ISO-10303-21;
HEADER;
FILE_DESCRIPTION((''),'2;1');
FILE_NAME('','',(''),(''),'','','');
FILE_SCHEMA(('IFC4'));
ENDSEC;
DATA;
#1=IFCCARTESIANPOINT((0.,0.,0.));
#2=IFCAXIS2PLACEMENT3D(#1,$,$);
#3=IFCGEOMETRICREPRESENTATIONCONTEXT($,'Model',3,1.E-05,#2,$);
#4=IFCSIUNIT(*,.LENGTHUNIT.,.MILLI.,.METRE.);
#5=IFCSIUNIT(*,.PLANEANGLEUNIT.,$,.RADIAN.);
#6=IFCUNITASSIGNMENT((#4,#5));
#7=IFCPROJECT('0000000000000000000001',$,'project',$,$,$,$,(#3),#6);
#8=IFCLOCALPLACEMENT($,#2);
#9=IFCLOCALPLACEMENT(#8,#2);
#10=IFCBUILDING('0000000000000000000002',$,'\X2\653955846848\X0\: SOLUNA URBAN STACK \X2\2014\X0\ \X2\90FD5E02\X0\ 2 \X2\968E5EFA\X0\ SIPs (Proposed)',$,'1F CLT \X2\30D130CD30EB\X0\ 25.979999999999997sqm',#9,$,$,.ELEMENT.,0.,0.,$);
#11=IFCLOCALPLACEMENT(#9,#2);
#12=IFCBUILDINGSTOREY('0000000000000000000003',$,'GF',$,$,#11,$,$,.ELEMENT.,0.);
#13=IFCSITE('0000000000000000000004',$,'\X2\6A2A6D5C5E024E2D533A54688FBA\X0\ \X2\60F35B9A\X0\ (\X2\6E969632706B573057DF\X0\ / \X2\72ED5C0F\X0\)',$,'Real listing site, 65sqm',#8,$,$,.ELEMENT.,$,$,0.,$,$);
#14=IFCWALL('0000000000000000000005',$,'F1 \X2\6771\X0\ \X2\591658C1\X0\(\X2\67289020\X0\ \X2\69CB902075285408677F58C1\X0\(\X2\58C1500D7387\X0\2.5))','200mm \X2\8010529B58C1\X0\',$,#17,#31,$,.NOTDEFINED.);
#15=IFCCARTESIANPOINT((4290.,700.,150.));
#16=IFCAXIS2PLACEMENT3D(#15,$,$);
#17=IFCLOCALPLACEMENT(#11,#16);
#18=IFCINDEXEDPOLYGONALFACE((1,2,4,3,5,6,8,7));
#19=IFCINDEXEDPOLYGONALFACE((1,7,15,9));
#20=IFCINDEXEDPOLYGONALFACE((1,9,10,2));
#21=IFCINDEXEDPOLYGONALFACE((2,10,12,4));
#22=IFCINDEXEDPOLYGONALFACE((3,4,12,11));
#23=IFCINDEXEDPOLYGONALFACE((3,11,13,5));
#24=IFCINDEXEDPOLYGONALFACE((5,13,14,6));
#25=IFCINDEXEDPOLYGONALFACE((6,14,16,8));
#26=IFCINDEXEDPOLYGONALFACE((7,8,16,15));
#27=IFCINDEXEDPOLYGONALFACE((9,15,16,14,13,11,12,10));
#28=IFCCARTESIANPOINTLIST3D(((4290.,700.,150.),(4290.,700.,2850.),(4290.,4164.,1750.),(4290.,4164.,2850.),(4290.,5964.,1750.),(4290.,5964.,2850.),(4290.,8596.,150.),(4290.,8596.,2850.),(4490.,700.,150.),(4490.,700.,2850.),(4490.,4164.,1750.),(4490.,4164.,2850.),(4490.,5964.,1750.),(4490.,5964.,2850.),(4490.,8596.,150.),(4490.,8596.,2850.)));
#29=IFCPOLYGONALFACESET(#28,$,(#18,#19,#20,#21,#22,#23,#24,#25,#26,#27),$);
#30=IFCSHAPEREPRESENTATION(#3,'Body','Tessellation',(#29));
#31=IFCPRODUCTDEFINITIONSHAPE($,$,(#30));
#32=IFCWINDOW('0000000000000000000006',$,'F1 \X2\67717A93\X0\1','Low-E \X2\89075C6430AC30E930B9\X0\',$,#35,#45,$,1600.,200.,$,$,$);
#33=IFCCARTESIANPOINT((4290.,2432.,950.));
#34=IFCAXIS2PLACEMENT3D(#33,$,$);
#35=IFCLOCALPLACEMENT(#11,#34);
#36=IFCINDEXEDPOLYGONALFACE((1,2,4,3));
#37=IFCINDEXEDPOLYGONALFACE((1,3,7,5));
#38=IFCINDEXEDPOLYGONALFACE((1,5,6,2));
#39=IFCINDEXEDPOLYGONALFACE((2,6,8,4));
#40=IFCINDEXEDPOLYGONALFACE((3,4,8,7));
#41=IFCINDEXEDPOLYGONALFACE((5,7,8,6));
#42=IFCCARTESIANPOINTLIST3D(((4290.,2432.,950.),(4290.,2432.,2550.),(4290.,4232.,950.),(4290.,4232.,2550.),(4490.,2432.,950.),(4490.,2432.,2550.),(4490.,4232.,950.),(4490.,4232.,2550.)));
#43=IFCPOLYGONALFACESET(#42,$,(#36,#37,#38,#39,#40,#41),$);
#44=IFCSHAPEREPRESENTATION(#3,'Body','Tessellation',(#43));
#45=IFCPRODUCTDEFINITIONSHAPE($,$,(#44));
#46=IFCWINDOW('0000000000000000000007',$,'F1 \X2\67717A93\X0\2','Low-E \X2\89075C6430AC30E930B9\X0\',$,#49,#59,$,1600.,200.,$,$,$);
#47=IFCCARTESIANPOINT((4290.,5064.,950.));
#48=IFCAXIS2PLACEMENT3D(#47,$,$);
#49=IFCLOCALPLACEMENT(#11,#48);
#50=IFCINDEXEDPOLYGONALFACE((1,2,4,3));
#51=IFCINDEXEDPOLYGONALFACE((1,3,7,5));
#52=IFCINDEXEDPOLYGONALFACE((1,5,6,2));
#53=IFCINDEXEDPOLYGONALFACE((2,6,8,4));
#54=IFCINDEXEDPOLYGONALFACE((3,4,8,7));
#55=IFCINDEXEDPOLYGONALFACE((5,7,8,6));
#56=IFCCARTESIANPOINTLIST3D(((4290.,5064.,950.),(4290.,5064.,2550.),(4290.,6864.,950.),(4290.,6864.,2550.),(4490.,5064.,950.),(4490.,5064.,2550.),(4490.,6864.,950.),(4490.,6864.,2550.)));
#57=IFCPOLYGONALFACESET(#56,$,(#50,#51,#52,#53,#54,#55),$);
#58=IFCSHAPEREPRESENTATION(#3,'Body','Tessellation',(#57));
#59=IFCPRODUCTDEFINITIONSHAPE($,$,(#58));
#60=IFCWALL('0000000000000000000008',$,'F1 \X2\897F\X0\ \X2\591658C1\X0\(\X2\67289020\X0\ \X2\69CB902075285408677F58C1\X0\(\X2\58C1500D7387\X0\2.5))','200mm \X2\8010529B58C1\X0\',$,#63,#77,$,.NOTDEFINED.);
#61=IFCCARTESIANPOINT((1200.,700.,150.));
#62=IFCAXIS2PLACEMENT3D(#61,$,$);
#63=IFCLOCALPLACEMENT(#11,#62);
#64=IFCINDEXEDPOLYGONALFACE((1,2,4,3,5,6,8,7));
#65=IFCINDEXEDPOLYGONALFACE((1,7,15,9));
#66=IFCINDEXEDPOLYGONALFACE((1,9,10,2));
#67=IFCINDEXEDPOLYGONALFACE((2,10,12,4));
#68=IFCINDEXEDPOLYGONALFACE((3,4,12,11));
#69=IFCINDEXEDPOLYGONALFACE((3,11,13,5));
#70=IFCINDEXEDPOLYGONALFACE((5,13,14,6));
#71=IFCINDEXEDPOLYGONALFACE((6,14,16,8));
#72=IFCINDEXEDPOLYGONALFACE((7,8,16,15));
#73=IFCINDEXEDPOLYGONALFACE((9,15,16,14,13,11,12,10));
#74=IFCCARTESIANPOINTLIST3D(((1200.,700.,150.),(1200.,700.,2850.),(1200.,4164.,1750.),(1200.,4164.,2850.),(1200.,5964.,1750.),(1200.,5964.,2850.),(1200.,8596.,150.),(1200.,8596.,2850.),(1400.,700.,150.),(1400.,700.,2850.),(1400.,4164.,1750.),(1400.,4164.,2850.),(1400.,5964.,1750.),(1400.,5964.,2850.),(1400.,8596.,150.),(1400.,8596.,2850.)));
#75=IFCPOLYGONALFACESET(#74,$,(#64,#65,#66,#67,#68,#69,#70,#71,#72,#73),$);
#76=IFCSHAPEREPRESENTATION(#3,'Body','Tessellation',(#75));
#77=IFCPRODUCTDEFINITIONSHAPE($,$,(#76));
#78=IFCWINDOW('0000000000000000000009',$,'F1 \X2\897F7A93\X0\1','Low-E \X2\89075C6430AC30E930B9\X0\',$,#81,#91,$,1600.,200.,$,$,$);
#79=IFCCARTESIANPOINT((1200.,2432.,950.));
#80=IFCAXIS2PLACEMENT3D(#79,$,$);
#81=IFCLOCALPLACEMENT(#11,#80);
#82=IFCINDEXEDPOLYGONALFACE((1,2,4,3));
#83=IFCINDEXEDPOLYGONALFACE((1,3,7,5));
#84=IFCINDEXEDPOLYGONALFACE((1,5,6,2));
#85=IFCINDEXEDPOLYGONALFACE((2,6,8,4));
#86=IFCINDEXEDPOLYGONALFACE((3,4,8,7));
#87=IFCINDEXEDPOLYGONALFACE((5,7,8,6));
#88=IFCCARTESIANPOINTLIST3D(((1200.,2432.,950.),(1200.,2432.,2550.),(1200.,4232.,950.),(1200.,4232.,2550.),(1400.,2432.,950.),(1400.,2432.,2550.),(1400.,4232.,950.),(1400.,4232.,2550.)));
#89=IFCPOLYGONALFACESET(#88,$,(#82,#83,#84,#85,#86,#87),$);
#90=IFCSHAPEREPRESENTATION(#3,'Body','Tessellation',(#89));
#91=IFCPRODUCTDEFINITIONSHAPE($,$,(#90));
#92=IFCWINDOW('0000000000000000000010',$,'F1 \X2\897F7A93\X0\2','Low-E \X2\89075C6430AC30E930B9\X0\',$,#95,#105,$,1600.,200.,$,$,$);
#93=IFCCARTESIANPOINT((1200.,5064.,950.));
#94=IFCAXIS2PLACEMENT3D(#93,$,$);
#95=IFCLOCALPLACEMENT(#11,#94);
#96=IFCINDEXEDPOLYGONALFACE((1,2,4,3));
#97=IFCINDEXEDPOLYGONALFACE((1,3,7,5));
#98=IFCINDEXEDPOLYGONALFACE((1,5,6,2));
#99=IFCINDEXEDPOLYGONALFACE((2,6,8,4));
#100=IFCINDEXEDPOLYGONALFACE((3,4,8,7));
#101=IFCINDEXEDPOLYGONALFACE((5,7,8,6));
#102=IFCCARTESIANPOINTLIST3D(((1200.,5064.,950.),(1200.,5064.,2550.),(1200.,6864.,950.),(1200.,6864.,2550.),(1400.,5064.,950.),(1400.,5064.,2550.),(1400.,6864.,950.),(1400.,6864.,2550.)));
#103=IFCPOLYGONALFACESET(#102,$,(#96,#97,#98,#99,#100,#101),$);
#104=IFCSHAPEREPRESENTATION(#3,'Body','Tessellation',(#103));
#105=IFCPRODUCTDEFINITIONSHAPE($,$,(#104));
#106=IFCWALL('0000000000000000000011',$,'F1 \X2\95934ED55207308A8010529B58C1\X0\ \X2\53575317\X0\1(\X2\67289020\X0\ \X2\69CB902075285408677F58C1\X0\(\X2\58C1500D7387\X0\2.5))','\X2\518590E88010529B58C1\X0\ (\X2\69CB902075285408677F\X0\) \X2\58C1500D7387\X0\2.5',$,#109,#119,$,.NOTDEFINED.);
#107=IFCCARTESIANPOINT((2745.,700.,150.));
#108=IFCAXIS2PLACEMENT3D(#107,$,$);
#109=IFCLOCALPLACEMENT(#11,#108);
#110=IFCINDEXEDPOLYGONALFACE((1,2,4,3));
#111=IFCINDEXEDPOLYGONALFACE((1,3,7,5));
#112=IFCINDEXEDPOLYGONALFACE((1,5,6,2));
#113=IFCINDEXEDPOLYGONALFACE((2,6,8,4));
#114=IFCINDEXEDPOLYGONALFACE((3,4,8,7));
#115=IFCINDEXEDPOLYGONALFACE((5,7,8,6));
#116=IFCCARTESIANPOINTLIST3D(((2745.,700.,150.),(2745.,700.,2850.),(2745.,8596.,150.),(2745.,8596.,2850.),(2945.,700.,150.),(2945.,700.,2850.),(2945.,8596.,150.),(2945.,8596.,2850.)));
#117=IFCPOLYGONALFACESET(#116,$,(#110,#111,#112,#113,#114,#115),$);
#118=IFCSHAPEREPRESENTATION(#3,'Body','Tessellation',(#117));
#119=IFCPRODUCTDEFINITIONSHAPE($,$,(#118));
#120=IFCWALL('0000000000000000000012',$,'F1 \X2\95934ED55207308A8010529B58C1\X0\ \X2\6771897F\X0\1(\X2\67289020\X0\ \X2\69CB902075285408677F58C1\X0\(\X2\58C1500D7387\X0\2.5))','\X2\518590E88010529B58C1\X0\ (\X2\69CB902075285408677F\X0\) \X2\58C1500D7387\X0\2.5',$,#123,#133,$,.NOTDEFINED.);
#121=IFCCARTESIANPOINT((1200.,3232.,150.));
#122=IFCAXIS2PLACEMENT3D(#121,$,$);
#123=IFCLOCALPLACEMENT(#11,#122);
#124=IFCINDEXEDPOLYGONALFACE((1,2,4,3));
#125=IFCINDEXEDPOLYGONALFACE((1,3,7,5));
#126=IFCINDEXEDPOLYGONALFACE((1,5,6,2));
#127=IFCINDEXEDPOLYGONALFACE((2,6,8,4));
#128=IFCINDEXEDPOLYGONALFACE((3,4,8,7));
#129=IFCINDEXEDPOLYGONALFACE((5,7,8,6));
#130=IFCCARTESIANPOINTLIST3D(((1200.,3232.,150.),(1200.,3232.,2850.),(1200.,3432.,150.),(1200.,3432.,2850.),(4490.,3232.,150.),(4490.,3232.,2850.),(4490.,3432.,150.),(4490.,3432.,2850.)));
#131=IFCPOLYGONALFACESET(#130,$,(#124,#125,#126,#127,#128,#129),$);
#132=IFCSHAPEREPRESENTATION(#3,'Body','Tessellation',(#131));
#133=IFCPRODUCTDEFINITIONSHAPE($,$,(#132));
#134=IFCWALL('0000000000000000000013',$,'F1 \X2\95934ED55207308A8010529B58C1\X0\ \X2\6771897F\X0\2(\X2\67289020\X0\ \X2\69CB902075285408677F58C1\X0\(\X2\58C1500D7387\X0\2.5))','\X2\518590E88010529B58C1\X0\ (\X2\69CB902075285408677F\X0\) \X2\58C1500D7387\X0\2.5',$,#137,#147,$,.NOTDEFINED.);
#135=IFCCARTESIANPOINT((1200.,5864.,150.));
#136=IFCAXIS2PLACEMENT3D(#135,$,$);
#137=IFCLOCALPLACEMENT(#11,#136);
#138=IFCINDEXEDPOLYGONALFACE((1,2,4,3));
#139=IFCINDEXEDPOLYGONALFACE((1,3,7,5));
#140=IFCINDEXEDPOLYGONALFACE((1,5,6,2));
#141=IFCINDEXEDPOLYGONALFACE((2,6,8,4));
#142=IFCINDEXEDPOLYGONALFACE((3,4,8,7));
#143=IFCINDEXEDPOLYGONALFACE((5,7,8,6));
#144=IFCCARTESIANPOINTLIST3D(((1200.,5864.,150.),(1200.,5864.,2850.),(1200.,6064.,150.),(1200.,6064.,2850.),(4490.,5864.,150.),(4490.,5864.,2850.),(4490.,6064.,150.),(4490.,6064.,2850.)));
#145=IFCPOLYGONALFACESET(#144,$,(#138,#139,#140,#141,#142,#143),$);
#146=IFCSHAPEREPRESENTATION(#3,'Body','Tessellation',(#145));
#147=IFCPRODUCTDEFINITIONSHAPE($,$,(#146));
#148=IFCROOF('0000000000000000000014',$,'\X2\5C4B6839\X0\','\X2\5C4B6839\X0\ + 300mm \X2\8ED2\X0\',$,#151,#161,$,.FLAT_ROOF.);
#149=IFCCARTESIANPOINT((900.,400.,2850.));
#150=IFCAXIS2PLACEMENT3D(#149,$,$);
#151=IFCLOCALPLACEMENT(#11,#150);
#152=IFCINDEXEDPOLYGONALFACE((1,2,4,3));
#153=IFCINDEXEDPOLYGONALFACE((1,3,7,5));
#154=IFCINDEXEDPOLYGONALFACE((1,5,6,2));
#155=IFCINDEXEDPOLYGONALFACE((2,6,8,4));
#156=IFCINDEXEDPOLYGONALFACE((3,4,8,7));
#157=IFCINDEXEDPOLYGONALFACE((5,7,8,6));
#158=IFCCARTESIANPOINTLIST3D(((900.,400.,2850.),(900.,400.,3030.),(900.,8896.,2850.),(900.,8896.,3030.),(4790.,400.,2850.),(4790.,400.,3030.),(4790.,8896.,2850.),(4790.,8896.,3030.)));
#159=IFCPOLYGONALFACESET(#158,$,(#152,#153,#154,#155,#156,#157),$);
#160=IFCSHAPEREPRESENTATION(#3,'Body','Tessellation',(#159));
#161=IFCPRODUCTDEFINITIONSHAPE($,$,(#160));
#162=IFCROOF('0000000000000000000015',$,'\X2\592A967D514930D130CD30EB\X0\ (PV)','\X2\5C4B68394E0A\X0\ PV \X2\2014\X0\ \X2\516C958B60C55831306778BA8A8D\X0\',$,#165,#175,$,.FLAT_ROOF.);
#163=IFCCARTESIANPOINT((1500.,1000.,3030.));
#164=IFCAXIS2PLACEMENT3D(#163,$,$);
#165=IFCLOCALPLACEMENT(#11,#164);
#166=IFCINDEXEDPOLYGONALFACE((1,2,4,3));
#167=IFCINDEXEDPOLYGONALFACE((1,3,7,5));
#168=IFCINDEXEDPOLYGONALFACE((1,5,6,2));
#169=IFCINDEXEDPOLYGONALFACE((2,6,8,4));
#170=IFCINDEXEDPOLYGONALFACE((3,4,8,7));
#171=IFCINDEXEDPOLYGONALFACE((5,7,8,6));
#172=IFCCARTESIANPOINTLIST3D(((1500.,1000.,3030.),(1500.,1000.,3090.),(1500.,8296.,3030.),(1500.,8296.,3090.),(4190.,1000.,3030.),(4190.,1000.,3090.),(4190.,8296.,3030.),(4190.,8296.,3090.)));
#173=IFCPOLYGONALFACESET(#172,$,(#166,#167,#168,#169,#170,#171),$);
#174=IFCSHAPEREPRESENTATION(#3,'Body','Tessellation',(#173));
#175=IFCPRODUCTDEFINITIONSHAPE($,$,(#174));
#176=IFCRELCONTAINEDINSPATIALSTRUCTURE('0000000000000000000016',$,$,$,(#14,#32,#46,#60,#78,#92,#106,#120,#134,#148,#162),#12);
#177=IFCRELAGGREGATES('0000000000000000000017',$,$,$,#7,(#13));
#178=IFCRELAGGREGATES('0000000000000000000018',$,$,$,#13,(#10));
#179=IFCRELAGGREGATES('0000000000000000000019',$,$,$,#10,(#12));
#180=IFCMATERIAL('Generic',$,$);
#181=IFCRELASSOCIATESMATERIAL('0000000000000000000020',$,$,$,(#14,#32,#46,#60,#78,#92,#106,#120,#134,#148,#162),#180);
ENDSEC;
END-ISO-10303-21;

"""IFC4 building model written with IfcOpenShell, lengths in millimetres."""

from ifc_helpers import new_model, si_unit, frame, frame_2d, origin, place, context, project, spatial, rectangle, extrude, material, element, fill, save


model = new_model("IFC4")

# Units and contexts
model_context = context("Model", 3, precision=1e-05, world=origin())
ifc_project = project(units=[si_unit("LENGTHUNIT", "METRE", prefix="MILLI"), si_unit("PLANEANGLEUNIT", "RADIAN")], contexts=[model_context])

# Site, building, storey
site_placement = place(None, origin())
site = spatial("IfcSite", under=ifc_project, at=site_placement, Name="横浜市中区周辺 想定 (準防火地域 / 狭小)", ObjectType="Real listing site, 65sqm", CompositionType="ELEMENT", RefElevation=0.0)
building_placement = place(site_placement, origin())
building = spatial("IfcBuilding", under=site, at=building_placement, Name="改善案: SOLUNA URBAN STACK — 都市 2 階建 SIPs (Proposed)", ObjectType="1F CLT パネル 25.979999999999997sqm", CompositionType="ELEMENT", ElevationOfRefHeight=0.0, ElevationOfTerrain=0.0)
storey_placement = place(building_placement, origin())
storey = spatial("IfcBuildingStorey", under=building, at=storey_placement, Name="GF", CompositionType="ELEMENT", Elevation=0.0)

# Shared definitions
ifc_material_1 = material(Name="Generic")

# Walls, openings, windows
wall_1_placement = place(storey_placement, frame((4290.0, 700.0, 150.0)))
wall_1 = element("IfcWall", 1, at=wall_1_placement, inside=storey, material=ifc_material_1, Name="F1 東 外壁(木造 構造用合板壁(壁倍率2.5))", Description="200mm 耐力壁", PredefinedType="NOTDEFINED", context=model_context, shape_type="SweptSolid", body=[
    extrude(rectangle(XDim=200.0, YDim=7896.0, at=frame_2d((100.0, 3948.0))), frame((4290.0, 700.0, 150.0)), (0.0, 0.0, 1.0), 2700.0),
])
opening_1_placement = place(storey_placement, frame((4290.0, 2432.0, 950.0)))
opening_1 = element("IfcOpeningElement", 2, at=opening_1_placement, cuts=wall_1, PredefinedType="NOTDEFINED", context=model_context, shape_type="SweptSolid", body=[
    extrude(rectangle(XDim=200.0, YDim=1800.0, at=frame_2d((100.0, 900.0))), frame((4290.0, 2432.0, 950.0)), (0.0, 0.0, 1.0), 1600.0),
])
opening_2_placement = place(storey_placement, frame((4290.0, 5064.0, 950.0)))
opening_2 = element("IfcOpeningElement", 3, at=opening_2_placement, cuts=wall_1, PredefinedType="NOTDEFINED", context=model_context, shape_type="SweptSolid", body=[
    extrude(rectangle(XDim=200.0, YDim=1800.0, at=frame_2d((100.0, 900.0))), frame((4290.0, 5064.0, 950.0)), (0.0, 0.0, 1.0), 1600.0),
])
window_1_placement = place(storey_placement, frame((4290.0, 2432.0, 950.0)))
window_1 = element("IfcWindow", 4, at=window_1_placement, inside=storey, material=ifc_material_1, Name="F1 東窓1", Description="Low-E 複層ガラス", OverallHeight=1600.0, OverallWidth=200.0, context=model_context, shape_type="SweptSolid", body=[
    extrude(rectangle(XDim=200.0, YDim=1800.0, at=frame_2d((100.0, 900.0))), frame((4290.0, 2432.0, 950.0)), (0.0, 0.0, 1.0), 1600.0),
])
fill(opening_1, window_1)
window_2_placement = place(storey_placement, frame((4290.0, 5064.0, 950.0)))
window_2 = element("IfcWindow", 5, at=window_2_placement, inside=storey, material=ifc_material_1, Name="F1 東窓2", Description="Low-E 複層ガラス", OverallHeight=1600.0, OverallWidth=200.0, context=model_context, shape_type="SweptSolid", body=[
    extrude(rectangle(XDim=200.0, YDim=1800.0, at=frame_2d((100.0, 900.0))), frame((4290.0, 5064.0, 950.0)), (0.0, 0.0, 1.0), 1600.0),
])
fill(opening_2, window_2)
wall_2_placement = place(storey_placement, frame((1200.0, 700.0, 150.0)))
wall_2 = element("IfcWall", 6, at=wall_2_placement, inside=storey, material=ifc_material_1, Name="F1 西 外壁(木造 構造用合板壁(壁倍率2.5))", Description="200mm 耐力壁", PredefinedType="NOTDEFINED", context=model_context, shape_type="SweptSolid", body=[
    extrude(rectangle(XDim=200.0, YDim=7896.0, at=frame_2d((100.0, 3948.0))), frame((1200.0, 700.0, 150.0)), (0.0, 0.0, 1.0), 2700.0),
])
opening_3_placement = place(storey_placement, frame((1200.0, 2432.0, 950.0)))
opening_3 = element("IfcOpeningElement", 7, at=opening_3_placement, cuts=wall_2, PredefinedType="NOTDEFINED", context=model_context, shape_type="SweptSolid", body=[
    extrude(rectangle(XDim=200.0, YDim=1800.0, at=frame_2d((100.0, 900.0))), frame((1200.0, 2432.0, 950.0)), (0.0, 0.0, 1.0), 1600.0),
])
opening_4_placement = place(storey_placement, frame((1200.0, 5064.0, 950.0)))
opening_4 = element("IfcOpeningElement", 8, at=opening_4_placement, cuts=wall_2, PredefinedType="NOTDEFINED", context=model_context, shape_type="SweptSolid", body=[
    extrude(rectangle(XDim=200.0, YDim=1800.0, at=frame_2d((100.0, 900.0))), frame((1200.0, 5064.0, 950.0)), (0.0, 0.0, 1.0), 1600.0),
])
window_3_placement = place(storey_placement, frame((1200.0, 2432.0, 950.0)))
window_3 = element("IfcWindow", 9, at=window_3_placement, inside=storey, material=ifc_material_1, Name="F1 西窓1", Description="Low-E 複層ガラス", OverallHeight=1600.0, OverallWidth=200.0, context=model_context, shape_type="SweptSolid", body=[
    extrude(rectangle(XDim=200.0, YDim=1800.0, at=frame_2d((100.0, 900.0))), frame((1200.0, 2432.0, 950.0)), (0.0, 0.0, 1.0), 1600.0),
])
fill(opening_3, window_3)
window_4_placement = place(storey_placement, frame((1200.0, 5064.0, 950.0)))
window_4 = element("IfcWindow", 10, at=window_4_placement, inside=storey, material=ifc_material_1, Name="F1 西窓2", Description="Low-E 複層ガラス", OverallHeight=1600.0, OverallWidth=200.0, context=model_context, shape_type="SweptSolid", body=[
    extrude(rectangle(XDim=200.0, YDim=1800.0, at=frame_2d((100.0, 900.0))), frame((1200.0, 5064.0, 950.0)), (0.0, 0.0, 1.0), 1600.0),
])
fill(opening_4, window_4)

# Walls
wall_3_placement = place(storey_placement, frame((2745.0, 700.0, 150.0)))
element("IfcWall", 11, at=wall_3_placement, inside=storey, material=ifc_material_1, Name="F1 間仕切り耐力壁 南北1(木造 構造用合板壁(壁倍率2.5))", Description="内部耐力壁 (構造用合板) 壁倍率2.5", PredefinedType="NOTDEFINED", context=model_context, shape_type="SweptSolid", body=[
    extrude(rectangle(XDim=200.0, YDim=7896.0, at=frame_2d((100.0, 3948.0))), frame((2745.0, 700.0, 150.0)), (0.0, 0.0, 1.0), 2700.0),
])
wall_4_placement = place(storey_placement, frame((1200.0, 3232.0, 150.0)))
element("IfcWall", 12, at=wall_4_placement, inside=storey, material=ifc_material_1, Name="F1 間仕切り耐力壁 東西1(木造 構造用合板壁(壁倍率2.5))", Description="内部耐力壁 (構造用合板) 壁倍率2.5", PredefinedType="NOTDEFINED", context=model_context, shape_type="SweptSolid", body=[
    extrude(rectangle(XDim=3290.0, YDim=200.0, at=frame_2d((1645.0, 100.0))), frame((1200.0, 3232.0, 150.0)), (0.0, 0.0, 1.0), 2700.0),
])
wall_5_placement = place(storey_placement, frame((1200.0, 5864.0, 150.0)))
element("IfcWall", 13, at=wall_5_placement, inside=storey, material=ifc_material_1, Name="F1 間仕切り耐力壁 東西2(木造 構造用合板壁(壁倍率2.5))", Description="内部耐力壁 (構造用合板) 壁倍率2.5", PredefinedType="NOTDEFINED", context=model_context, shape_type="SweptSolid", body=[
    extrude(rectangle(XDim=3290.0, YDim=200.0, at=frame_2d((1645.0, 100.0))), frame((1200.0, 5864.0, 150.0)), (0.0, 0.0, 1.0), 2700.0),
])

# Roofs
roof_1_placement = place(storey_placement, frame((900.0, 400.0, 2850.0)))
element("IfcRoof", 14, at=roof_1_placement, inside=storey, material=ifc_material_1, Name="屋根", Description="屋根 + 300mm 軒", PredefinedType="FLAT_ROOF", context=model_context, shape_type="SweptSolid", body=[
    extrude(rectangle(XDim=3890.0, YDim=8496.0, at=frame_2d((1945.0, 4248.0))), frame((900.0, 400.0, 2850.0)), (0.0, 0.0, 1.0), 180.0),
])
roof_2_placement = place(storey_placement, frame((1500.0, 1000.0, 3030.0)))
element("IfcRoof", 15, at=roof_2_placement, inside=storey, material=ifc_material_1, Name="太陽光パネル (PV)", Description="屋根上 PV — 公開情報で確認", PredefinedType="FLAT_ROOF", context=model_context, shape_type="SweptSolid", body=[
    extrude(rectangle(XDim=2690.0, YDim=7296.0, at=frame_2d((1345.0, 3648.0))), frame((1500.0, 1000.0, 3030.0)), (0.0, 0.0, 1.0), 60.0),
])

save(model, "model.ifc")
